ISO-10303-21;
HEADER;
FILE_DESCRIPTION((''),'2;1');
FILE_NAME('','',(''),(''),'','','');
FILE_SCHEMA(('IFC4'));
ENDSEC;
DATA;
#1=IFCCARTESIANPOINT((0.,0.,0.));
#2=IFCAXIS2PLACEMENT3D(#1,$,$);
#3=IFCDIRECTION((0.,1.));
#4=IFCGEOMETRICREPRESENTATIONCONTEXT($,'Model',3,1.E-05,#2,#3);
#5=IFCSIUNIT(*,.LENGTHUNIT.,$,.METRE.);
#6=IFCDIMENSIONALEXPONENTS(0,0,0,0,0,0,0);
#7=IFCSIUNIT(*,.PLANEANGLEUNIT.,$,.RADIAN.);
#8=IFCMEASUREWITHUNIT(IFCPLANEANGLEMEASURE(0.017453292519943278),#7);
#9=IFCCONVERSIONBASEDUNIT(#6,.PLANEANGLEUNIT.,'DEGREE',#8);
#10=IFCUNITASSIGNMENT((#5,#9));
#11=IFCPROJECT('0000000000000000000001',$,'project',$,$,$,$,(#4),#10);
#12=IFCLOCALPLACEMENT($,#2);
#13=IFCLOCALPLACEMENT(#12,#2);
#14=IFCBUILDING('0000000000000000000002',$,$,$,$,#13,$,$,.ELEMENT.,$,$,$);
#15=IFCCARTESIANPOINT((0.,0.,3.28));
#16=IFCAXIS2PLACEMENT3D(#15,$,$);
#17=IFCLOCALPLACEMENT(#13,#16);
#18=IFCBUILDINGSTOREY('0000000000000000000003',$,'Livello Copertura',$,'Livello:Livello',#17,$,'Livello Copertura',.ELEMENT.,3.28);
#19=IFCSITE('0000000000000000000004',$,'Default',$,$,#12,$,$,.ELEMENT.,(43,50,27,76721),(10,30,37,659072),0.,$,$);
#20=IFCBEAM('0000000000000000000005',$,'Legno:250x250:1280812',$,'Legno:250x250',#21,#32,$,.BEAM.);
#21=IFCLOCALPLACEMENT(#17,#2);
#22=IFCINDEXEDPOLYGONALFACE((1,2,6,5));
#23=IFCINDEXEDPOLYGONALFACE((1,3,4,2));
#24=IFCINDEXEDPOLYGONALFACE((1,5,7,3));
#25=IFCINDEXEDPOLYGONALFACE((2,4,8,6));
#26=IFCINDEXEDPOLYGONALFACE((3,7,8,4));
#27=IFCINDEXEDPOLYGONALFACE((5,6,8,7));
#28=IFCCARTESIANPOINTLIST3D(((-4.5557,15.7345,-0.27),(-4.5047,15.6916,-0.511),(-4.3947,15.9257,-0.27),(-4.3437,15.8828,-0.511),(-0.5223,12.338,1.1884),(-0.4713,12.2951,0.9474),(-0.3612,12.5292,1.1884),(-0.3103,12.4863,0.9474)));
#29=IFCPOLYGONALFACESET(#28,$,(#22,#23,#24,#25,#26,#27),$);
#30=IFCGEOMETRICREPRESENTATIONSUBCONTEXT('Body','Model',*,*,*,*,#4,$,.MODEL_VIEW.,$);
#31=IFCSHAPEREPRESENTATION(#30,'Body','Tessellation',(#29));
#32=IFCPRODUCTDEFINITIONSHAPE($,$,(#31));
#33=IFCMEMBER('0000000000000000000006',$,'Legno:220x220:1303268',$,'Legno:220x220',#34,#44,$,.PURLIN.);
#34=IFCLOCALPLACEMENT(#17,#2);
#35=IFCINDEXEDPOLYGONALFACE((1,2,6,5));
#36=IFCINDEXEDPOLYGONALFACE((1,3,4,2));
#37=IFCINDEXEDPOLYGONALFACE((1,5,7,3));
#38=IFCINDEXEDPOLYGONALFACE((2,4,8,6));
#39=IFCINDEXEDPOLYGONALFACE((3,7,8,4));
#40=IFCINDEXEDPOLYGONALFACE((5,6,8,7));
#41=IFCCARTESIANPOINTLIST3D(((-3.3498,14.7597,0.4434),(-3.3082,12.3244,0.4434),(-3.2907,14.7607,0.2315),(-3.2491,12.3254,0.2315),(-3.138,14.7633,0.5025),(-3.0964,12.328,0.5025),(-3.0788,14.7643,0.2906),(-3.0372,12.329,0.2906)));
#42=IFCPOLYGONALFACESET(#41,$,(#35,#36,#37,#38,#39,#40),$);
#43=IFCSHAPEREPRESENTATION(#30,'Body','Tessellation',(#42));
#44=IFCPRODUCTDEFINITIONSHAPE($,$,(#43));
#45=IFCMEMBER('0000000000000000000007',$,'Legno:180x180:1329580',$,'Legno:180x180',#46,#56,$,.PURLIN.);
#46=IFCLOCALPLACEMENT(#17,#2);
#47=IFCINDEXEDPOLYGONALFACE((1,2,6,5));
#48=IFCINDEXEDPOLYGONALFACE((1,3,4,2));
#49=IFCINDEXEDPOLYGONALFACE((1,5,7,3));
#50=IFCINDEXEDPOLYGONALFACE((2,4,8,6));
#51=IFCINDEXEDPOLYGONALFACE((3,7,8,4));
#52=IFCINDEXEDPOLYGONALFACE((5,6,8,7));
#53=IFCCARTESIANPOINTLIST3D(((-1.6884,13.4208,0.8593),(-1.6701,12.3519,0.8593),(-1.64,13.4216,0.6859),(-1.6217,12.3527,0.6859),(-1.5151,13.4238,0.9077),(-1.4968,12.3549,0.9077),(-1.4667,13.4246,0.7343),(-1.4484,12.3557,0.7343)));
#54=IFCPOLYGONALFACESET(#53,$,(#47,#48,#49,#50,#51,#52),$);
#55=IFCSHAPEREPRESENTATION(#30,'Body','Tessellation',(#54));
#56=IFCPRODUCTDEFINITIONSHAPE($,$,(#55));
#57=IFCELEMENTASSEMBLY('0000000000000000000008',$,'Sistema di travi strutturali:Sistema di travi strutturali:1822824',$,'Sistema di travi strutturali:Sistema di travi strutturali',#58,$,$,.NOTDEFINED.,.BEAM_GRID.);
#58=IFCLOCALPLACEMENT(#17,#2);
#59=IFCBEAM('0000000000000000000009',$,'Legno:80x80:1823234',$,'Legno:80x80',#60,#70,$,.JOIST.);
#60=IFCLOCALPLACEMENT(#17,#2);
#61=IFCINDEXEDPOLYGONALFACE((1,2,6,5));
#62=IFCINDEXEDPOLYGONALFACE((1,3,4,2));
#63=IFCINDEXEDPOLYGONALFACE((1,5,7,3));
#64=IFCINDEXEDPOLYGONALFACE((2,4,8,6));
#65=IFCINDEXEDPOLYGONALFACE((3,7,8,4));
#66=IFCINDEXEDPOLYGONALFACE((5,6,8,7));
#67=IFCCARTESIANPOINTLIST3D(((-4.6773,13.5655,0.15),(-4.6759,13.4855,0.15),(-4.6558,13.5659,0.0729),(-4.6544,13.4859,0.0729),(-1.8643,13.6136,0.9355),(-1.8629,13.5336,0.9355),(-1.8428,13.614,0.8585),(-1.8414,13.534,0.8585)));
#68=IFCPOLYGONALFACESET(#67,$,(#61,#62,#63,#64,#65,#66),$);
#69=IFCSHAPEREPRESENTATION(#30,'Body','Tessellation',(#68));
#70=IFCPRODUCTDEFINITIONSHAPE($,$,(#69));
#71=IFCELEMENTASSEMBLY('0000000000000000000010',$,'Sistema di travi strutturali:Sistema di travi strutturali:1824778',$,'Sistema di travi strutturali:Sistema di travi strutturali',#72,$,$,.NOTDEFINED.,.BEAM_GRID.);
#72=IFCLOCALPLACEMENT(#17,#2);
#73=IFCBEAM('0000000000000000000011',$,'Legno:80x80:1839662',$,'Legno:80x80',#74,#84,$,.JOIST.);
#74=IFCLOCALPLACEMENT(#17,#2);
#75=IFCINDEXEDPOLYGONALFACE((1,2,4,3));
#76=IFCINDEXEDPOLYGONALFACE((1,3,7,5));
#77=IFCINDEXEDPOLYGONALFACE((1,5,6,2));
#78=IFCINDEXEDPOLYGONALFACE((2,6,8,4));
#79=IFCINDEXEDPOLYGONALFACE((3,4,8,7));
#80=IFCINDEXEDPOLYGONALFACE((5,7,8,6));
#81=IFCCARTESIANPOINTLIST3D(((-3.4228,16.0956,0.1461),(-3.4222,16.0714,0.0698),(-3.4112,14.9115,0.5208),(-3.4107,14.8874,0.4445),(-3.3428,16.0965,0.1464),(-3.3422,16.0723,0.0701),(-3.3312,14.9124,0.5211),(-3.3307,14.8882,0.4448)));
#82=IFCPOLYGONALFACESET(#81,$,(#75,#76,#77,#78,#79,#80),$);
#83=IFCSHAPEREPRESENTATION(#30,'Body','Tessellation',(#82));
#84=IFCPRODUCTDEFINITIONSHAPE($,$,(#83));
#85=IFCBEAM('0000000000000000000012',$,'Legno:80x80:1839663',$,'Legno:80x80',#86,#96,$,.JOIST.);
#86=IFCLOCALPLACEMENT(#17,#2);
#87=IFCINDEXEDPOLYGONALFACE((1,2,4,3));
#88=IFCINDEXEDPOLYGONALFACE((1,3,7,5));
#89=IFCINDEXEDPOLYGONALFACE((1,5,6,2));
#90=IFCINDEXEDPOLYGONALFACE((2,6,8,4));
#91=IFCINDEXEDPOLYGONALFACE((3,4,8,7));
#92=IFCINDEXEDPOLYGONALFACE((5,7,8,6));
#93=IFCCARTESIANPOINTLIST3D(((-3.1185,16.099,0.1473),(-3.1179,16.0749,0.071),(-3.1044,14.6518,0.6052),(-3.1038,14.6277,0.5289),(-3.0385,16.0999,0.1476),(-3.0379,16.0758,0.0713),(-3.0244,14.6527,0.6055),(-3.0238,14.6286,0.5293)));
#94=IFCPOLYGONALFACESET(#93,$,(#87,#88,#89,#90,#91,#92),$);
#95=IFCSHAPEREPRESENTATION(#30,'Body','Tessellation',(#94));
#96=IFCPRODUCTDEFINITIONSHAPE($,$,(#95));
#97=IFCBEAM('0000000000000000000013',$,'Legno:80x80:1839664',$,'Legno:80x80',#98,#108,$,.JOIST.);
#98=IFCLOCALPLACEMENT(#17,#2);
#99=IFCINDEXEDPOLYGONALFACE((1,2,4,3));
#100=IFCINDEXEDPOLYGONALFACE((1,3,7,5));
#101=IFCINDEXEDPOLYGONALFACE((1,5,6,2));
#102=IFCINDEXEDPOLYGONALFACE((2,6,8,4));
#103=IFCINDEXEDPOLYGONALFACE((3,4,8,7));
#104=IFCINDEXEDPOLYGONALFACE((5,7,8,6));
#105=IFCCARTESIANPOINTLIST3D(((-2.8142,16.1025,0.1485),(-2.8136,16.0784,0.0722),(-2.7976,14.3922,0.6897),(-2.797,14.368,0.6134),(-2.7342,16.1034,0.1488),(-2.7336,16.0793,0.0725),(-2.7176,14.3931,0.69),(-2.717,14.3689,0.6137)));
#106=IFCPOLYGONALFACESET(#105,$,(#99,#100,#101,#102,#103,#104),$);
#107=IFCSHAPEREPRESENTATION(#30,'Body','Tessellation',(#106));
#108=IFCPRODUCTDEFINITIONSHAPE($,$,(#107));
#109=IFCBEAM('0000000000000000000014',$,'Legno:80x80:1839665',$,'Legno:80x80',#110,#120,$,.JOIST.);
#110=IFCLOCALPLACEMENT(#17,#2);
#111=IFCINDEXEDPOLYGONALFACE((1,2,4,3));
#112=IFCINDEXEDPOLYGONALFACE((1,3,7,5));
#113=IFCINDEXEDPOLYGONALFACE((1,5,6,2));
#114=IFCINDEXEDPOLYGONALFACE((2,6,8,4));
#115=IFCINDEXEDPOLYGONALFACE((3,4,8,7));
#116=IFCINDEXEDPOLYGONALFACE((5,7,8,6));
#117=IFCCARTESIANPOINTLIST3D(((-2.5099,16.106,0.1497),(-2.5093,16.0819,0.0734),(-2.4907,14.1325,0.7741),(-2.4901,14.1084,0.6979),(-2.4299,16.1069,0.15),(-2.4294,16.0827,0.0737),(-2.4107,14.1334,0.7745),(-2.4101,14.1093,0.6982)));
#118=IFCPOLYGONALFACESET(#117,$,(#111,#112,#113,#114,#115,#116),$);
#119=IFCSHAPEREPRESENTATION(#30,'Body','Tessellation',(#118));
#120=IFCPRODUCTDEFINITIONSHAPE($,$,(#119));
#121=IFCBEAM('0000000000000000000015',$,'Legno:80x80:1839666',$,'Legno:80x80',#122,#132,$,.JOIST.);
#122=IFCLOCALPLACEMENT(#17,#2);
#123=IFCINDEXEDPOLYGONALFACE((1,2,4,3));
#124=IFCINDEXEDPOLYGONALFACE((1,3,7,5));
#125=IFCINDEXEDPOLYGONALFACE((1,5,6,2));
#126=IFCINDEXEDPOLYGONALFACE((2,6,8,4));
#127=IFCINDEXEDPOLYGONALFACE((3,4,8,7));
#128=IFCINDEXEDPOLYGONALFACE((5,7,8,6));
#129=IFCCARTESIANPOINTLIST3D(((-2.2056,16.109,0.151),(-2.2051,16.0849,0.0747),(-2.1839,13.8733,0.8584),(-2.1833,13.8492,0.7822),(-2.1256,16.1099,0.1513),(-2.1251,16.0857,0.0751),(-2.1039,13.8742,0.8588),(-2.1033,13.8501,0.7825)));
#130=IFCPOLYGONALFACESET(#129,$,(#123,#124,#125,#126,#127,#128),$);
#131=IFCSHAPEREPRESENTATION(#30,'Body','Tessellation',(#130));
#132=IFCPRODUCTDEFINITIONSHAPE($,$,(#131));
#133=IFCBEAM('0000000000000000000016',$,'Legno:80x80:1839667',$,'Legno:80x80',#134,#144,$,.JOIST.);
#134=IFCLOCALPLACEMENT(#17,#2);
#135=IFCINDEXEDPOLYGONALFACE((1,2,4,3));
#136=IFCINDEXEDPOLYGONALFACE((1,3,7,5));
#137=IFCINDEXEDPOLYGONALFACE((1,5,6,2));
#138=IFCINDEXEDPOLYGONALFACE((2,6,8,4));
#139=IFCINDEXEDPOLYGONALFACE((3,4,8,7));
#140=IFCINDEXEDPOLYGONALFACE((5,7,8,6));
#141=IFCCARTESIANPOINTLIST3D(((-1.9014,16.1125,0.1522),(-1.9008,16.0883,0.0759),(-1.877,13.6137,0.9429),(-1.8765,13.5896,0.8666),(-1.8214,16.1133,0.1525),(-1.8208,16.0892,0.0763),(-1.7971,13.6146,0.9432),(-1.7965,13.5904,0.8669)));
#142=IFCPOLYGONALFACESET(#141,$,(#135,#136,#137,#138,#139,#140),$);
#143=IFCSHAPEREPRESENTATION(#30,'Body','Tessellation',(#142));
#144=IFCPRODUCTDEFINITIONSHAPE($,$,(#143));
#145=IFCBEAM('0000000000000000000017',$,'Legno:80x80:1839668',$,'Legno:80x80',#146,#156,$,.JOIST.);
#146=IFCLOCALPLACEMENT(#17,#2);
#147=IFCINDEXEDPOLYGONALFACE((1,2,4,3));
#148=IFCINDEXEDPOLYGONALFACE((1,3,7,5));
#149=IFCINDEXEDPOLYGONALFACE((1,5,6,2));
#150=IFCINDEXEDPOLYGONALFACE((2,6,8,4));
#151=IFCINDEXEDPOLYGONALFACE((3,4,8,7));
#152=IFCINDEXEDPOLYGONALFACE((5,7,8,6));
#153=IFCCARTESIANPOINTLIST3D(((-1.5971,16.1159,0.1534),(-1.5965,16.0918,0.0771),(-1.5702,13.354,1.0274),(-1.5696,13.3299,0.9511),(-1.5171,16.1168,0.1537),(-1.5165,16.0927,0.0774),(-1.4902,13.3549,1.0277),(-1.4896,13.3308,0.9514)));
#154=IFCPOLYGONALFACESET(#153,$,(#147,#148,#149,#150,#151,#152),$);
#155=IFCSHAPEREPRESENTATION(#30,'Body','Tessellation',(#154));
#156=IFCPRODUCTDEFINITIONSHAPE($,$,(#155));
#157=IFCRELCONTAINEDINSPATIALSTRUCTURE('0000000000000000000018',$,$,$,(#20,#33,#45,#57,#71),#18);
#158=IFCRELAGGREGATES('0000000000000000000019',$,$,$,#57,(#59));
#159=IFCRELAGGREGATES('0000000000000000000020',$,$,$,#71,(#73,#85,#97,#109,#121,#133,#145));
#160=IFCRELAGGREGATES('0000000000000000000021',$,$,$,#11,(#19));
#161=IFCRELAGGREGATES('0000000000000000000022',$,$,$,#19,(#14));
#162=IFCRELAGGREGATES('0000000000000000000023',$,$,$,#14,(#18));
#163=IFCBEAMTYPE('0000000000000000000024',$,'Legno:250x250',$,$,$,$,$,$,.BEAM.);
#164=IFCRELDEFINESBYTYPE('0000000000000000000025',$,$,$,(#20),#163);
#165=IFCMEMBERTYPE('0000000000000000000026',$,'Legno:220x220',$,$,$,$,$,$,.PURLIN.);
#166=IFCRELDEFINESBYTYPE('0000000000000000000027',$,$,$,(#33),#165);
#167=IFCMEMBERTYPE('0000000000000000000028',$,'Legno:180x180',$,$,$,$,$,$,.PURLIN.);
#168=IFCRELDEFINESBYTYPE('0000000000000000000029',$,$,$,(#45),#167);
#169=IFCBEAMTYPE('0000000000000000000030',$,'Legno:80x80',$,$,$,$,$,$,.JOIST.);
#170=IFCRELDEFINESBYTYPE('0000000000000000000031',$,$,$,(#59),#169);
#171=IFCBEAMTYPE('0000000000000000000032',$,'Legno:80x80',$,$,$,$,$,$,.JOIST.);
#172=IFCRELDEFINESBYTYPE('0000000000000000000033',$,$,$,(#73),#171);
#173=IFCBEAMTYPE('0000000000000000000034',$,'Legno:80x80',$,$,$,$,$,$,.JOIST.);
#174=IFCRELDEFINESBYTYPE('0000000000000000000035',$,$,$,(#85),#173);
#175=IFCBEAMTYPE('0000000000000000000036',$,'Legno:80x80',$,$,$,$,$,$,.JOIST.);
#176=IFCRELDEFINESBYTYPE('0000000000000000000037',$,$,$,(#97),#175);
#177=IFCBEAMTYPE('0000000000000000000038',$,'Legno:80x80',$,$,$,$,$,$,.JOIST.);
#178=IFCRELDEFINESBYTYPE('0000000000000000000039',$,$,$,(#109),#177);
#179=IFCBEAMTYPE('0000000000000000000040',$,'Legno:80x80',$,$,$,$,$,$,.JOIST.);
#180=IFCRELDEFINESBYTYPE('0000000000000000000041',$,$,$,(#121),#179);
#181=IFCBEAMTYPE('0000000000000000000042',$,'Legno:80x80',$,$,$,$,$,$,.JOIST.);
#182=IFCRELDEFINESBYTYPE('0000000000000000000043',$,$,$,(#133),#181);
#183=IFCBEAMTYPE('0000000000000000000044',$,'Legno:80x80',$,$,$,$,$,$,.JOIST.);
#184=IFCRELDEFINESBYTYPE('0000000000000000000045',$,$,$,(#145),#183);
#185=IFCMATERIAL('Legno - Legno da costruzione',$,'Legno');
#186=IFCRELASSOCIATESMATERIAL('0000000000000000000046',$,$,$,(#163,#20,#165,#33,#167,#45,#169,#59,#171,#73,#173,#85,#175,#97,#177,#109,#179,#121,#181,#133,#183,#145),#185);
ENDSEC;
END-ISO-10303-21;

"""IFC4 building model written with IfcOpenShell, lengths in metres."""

from ifc_helpers import new_model, entity, si_unit, converted_unit, direction, frame, origin, place, context, subcontext, project, spatial, indexed_curve, outline, extrude, source, transform, mapped, material, type_object, type_shapes, element, aggregate, save


model = new_model("IFC4")

# Units and contexts
model_context = context("Model", 3, precision=1e-05, world=origin(), true_north=direction((0.0, 1.0)))
body_context = subcontext(model_context, "Body", "Model", "MODEL_VIEW")
ifc_project = project(units=[si_unit("LENGTHUNIT", "METRE"), converted_unit("PLANEANGLEUNIT", "DEGREE", entity("IfcPlaneAngleMeasure", 0.017453292519943278), si_unit("PLANEANGLEUNIT", "RADIAN"), dimensions=[0, 0, 0, 0, 0, 0, 0])], contexts=[model_context])

# Site, building, storey
site_placement = place(None, origin())
site = spatial("IfcSite", under=ifc_project, at=site_placement, Name="Default", CompositionType="ELEMENT", RefLatitude=(43, 50, 27, 76721), RefLongitude=(10, 30, 37, 659072), RefElevation=0.0)
building_placement = place(site_placement, origin())
building = spatial("IfcBuilding", under=site, at=building_placement, CompositionType="ELEMENT")
storey_placement = place(building_placement, frame((0.0, 0.0, 3.28)))
storey = spatial("IfcBuildingStorey", under=building, at=storey_placement, Name="Livello Copertura", ObjectType="Livello:Livello", LongName="Livello Copertura", CompositionType="ELEMENT", Elevation=3.28)

# Beam
ifc_material = material(Name="Legno - Legno da costruzione", Category="Legno")
beam_type_1 = type_object("IfcBeamType", Name="Legno:250x250", PredefinedType="BEAM", material=ifc_material)
shared_shape_1 = source(origin(), body_context, "Body", "SweptSolid", [
    extrude(outline(indexed_curve([(-0.125, -2.7355), (0.125, -2.7355), (0.125, 2.7355), (-0.125, 2.7355), (-0.125, -2.7355)], self_intersect=False)), frame((-0.095, 0.0, -0.125), z_axis=(0.0, 0.0, 1.0), x_axis=(0.0, 1.0, 0.0)), (0.0, 0.0, 1.0), 0.25),
])
type_shapes(beam_type_1, [shared_shape_1])
beam_1_placement = place(storey_placement, frame((-2.3629, 14.0514, 0.364), z_axis=(-0.203897, 0.171699, 0.963818), x_axis=(0.737242, -0.620821, 0.266561)))
element("IfcBeam", 1, at=beam_1_placement, inside=storey, type_object=beam_type_1, material=ifc_material, Name="Legno:250x250:1280812", ObjectType="Legno:250x250", PredefinedType="BEAM", context=body_context, shape_type="MappedRepresentation", body=[
    mapped(shared_shape_1, transform((0.0, 0.0, 0.0), scale=1.0)),
])

# Members
member_type_1 = type_object("IfcMemberType", Name="Legno:220x220", PredefinedType="PURLIN", material=ifc_material)
shared_shape_2 = source(origin(), body_context, "Body", "SweptSolid", [
    extrude(outline(indexed_curve([(-1.2178, -0.11), (1.2178, -0.11), (1.2178, 0.11), (-1.2178, 0.11), (-1.2178, -0.11)], self_intersect=False)), frame((0.7007, 0.0, -0.11), z_axis=(0.0, 0.0, 1.0), x_axis=(-1.0, 0.0, 0.0)), (0.0, 0.0, 1.0), 0.22),
])
type_shapes(member_type_1, [shared_shape_2])
member_1_placement = place(storey_placement, frame((-3.2055, 14.2449, 0.367), z_axis=(-0.268881, -0.004594, 0.963163), x_axis=(0.017085, -0.999854, 0.0)))
element("IfcMember", 2, at=member_1_placement, inside=storey, type_object=member_type_1, material=ifc_material, Name="Legno:220x220:1303268", ObjectType="Legno:220x220", PredefinedType="PURLIN", context=body_context, shape_type="MappedRepresentation", body=[
    mapped(shared_shape_2, transform((0.0, 0.0, 0.0), scale=1.0)),
])
member_type_2 = type_object("IfcMemberType", Name="Legno:180x180", PredefinedType="PURLIN", material=ifc_material)
shared_shape_3 = source(origin(), body_context, "Body", "SweptSolid", [
    extrude(outline(indexed_curve([(-0.5345, -0.09), (0.5345, -0.09), (0.5345, 0.09), (-0.5345, 0.09), (-0.5345, -0.09)], self_intersect=False)), frame((1.3845, 0.0, -0.09), z_axis=(0.0, 0.0, 1.0), x_axis=(-1.0, 0.0, 0.0)), (0.0, 0.0, 1.0), 0.18),
])
type_shapes(member_type_2, [shared_shape_3])
member_2_placement = place(storey_placement, frame((-1.5921, 14.2725, 0.7968), z_axis=(-0.268881, -0.004594, 0.963163), x_axis=(0.017085, -0.999854, 0.0)))
element("IfcMember", 3, at=member_2_placement, inside=storey, type_object=member_type_2, material=ifc_material, Name="Legno:180x180:1329580", ObjectType="Legno:180x180", PredefinedType="PURLIN", context=body_context, shape_type="MappedRepresentation", body=[
    mapped(shared_shape_3, transform((0.0, 0.0, 0.0), scale=1.0)),
])

# Element assembly, beam
assembly_1_placement = place(storey_placement, origin())
assembly_1 = element("IfcElementAssembly", 4, at=assembly_1_placement, inside=storey, Name="Sistema di travi strutturali:Sistema di travi strutturali:1822824", ObjectType="Sistema di travi strutturali:Sistema di travi strutturali", AssemblyPlace="NOTDEFINED", PredefinedType="BEAM_GRID")
beam_type_2 = type_object("IfcBeamType", Name="Legno:80x80", PredefinedType="JOIST", material=ifc_material)
shared_shape_4 = source(origin(), body_context, "Body", "SweptSolid", [
    extrude(outline(indexed_curve([(-1.4605, -0.04), (1.4605, -0.04), (1.4605, 0.04), (-1.4605, 0.04), (-1.4605, -0.04)], self_intersect=False)), frame((0.0, 0.0, -0.04), z_axis=(0.0, 0.0, 1.0), x_axis=(-1.0, 0.0, 0.0)), (0.0, 0.0, 1.0), 0.08),
])
type_shapes(beam_type_2, [shared_shape_4])
beam_2_placement = place(assembly_1_placement, frame((-3.2593, 13.5498, 0.5042), z_axis=(-0.268881, -0.004594, 0.963163), x_axis=(0.963022, 0.016456, 0.26892)))
beam_2 = element("IfcBeam", 5, at=beam_2_placement, type_object=beam_type_2, material=ifc_material, Name="Legno:80x80:1823234", ObjectType="Legno:80x80", PredefinedType="JOIST", context=body_context, shape_type="MappedRepresentation", body=[
    mapped(shared_shape_4, transform((0.0, 0.0, 0.0), scale=1.0)),
])
aggregate(assembly_1, [beam_2])

# Element assembly, beams
assembly_2_placement = place(storey_placement, origin())
assembly_2 = element("IfcElementAssembly", 6, at=assembly_2_placement, inside=storey, Name="Sistema di travi strutturali:Sistema di travi strutturali:1824778", ObjectType="Sistema di travi strutturali:Sistema di travi strutturali", AssemblyPlace="NOTDEFINED", PredefinedType="BEAM_GRID")
beam_type_3 = type_object("IfcBeamType", Name="Legno:80x80", PredefinedType="JOIST", material=ifc_material)
shared_shape_5 = source(origin(), body_context, "Body", "SweptSolid", [
    extrude(outline(indexed_curve([(-0.621, -0.04), (0.621, -0.04), (0.621, 0.04), (-0.621, 0.04), (-0.621, -0.04)], self_intersect=False)), frame((0.0, 0.0, -0.04), z_axis=(0.0, 0.0, 1.0), x_axis=(-1.0, 0.0, 0.0)), (0.0, 0.0, 1.0), 0.08),
])
type_shapes(beam_type_3, [shared_shape_5])
beam_3_placement = place(assembly_2_placement, frame((-3.3767, 15.4919, 0.2954), z_axis=(-0.007187, 0.301619, 0.953402), x_axis=(0.009277, -0.953365, 0.301677)))
beam_3 = element("IfcBeam", 7, at=beam_3_placement, type_object=beam_type_3, material=ifc_material, Name="Legno:80x80:1839662", ObjectType="Legno:80x80", PredefinedType="JOIST", context=body_context, shape_type="MappedRepresentation", body=[
    mapped(shared_shape_5, transform((0.0, 0.0, 0.0), scale=1.0)),
])
beam_type_4 = type_object("IfcBeamType", Name="Legno:80x80", PredefinedType="JOIST", material=ifc_material)
shared_shape_6 = source(origin(), body_context, "Body", "SweptSolid", [
    extrude(outline(indexed_curve([(-0.759, -0.04), (0.759, -0.04), (0.759, 0.04), (-0.759, 0.04), (-0.759, -0.04)], self_intersect=False)), frame((0.0, 0.0, -0.04), z_axis=(0.0, 0.0, 1.0), x_axis=(-1.0, 0.0, 0.0)), (0.0, 0.0, 1.0), 0.08),
])
type_shapes(beam_type_4, [shared_shape_6])
beam_4_placement = place(assembly_2_placement, frame((-3.0712, 15.3638, 0.3383), z_axis=(-0.007187, 0.301619, 0.953402), x_axis=(0.009277, -0.953365, 0.301677)))
beam_4 = element("IfcBeam", 8, at=beam_4_placement, type_object=beam_type_4, material=ifc_material, Name="Legno:80x80:1839663", ObjectType="Legno:80x80", PredefinedType="JOIST", context=body_context, shape_type="MappedRepresentation", body=[
    mapped(shared_shape_6, transform((0.0, 0.0, 0.0), scale=1.0)),
])
beam_type_5 = type_object("IfcBeamType", Name="Legno:80x80", PredefinedType="JOIST", material=ifc_material)
shared_shape_7 = source(origin(), body_context, "Body", "SweptSolid", [
    extrude(outline(indexed_curve([(-0.897, -0.04), (0.897, -0.04), (0.897, 0.04), (-0.897, 0.04), (-0.897, -0.04)], self_intersect=False)), frame((0.0, 0.0, -0.04), z_axis=(0.0, 0.0, 1.0), x_axis=(-1.0, 0.0, 0.0)), (0.0, 0.0, 1.0), 0.08),
])
type_shapes(beam_type_5, [shared_shape_7])
beam_5_placement = place(assembly_2_placement, frame((-2.7656, 15.2357, 0.3811), z_axis=(-0.007187, 0.301619, 0.953402), x_axis=(0.009277, -0.953365, 0.301677)))
beam_5 = element("IfcBeam", 9, at=beam_5_placement, type_object=beam_type_5, material=ifc_material, Name="Legno:80x80:1839664", ObjectType="Legno:80x80", PredefinedType="JOIST", context=body_context, shape_type="MappedRepresentation", body=[
    mapped(shared_shape_7, transform((0.0, 0.0, 0.0), scale=1.0)),
])
beam_type_6 = type_object("IfcBeamType", Name="Legno:80x80", PredefinedType="JOIST", material=ifc_material)
shared_shape_8 = source(origin(), body_context, "Body", "SweptSolid", [
    extrude(outline(indexed_curve([(-1.035, -0.04), (1.035, -0.04), (1.035, 0.04), (-1.035, 0.04), (-1.035, -0.04)], self_intersect=False)), frame((0.0, 0.0, -0.04), z_axis=(0.0, 0.0, 1.0), x_axis=(-1.0, 0.0, 0.0)), (0.0, 0.0, 1.0), 0.08),
])
type_shapes(beam_type_6, [shared_shape_8])
beam_6_placement = place(assembly_2_placement, frame((-2.46, 15.1076, 0.4239), z_axis=(-0.007187, 0.301619, 0.953402), x_axis=(0.009277, -0.953365, 0.301677)))
beam_6 = element("IfcBeam", 10, at=beam_6_placement, type_object=beam_type_6, material=ifc_material, Name="Legno:80x80:1839665", ObjectType="Legno:80x80", PredefinedType="JOIST", context=body_context, shape_type="MappedRepresentation", body=[
    mapped(shared_shape_8, transform((0.0, 0.0, 0.0), scale=1.0)),
])
beam_type_7 = type_object("IfcBeamType", Name="Legno:80x80", PredefinedType="JOIST", material=ifc_material)
shared_shape_9 = source(origin(), body_context, "Body", "SweptSolid", [
    extrude(outline(indexed_curve([(-1.1725, -0.04), (1.1725, -0.04), (1.1725, 0.04), (-1.1725, 0.04), (-1.1725, -0.04)], self_intersect=False)), frame((0.0, 0.0, -0.04), z_axis=(0.0, 0.0, 1.0), x_axis=(-1.0, 0.0, 0.0)), (0.0, 0.0, 1.0), 0.08),
])
type_shapes(beam_type_7, [shared_shape_9])
beam_7_placement = place(assembly_2_placement, frame((-2.1545, 14.9795, 0.4667), z_axis=(-0.007187, 0.301619, 0.953402), x_axis=(0.009277, -0.953365, 0.301677)))
beam_7 = element("IfcBeam", 11, at=beam_7_placement, type_object=beam_type_7, material=ifc_material, Name="Legno:80x80:1839666", ObjectType="Legno:80x80", PredefinedType="JOIST", context=body_context, shape_type="MappedRepresentation", body=[
    mapped(shared_shape_9, transform((0.0, 0.0, 0.0), scale=1.0)),
])
beam_type_8 = type_object("IfcBeamType", Name="Legno:80x80", PredefinedType="JOIST", material=ifc_material)
shared_shape_10 = source(origin(), body_context, "Body", "SweptSolid", [
    extrude(outline(indexed_curve([(-1.3105, -0.04), (1.3105, -0.04), (1.3105, 0.04), (-1.3105, 0.04), (-1.3105, -0.04)], self_intersect=False)), frame((0.0, 0.0, -0.04), z_axis=(0.0, 0.0, 1.0), x_axis=(-1.0, 0.0, 0.0)), (0.0, 0.0, 1.0), 0.08),
])
type_shapes(beam_type_8, [shared_shape_10])
beam_8_placement = place(assembly_2_placement, frame((-1.8489, 14.8514, 0.5096), z_axis=(-0.007187, 0.301619, 0.953402), x_axis=(0.009277, -0.953365, 0.301677)))
beam_8 = element("IfcBeam", 12, at=beam_8_placement, type_object=beam_type_8, material=ifc_material, Name="Legno:80x80:1839667", ObjectType="Legno:80x80", PredefinedType="JOIST", context=body_context, shape_type="MappedRepresentation", body=[
    mapped(shared_shape_10, transform((0.0, 0.0, 0.0), scale=1.0)),
])
beam_type_9 = type_object("IfcBeamType", Name="Legno:80x80", PredefinedType="JOIST", material=ifc_material)
shared_shape_11 = source(origin(), body_context, "Body", "SweptSolid", [
    extrude(outline(indexed_curve([(-1.4485, -0.04), (1.4485, -0.04), (1.4485, 0.04), (-1.4485, 0.04), (-1.4485, -0.04)], self_intersect=False)), frame((0.0, 0.0, -0.04), z_axis=(0.0, 0.0, 1.0), x_axis=(-1.0, 0.0, 0.0)), (0.0, 0.0, 1.0), 0.08),
])
type_shapes(beam_type_9, [shared_shape_11])
beam_9_placement = place(assembly_2_placement, frame((-1.5434, 14.7234, 0.5524), z_axis=(-0.007187, 0.301619, 0.953402), x_axis=(0.009277, -0.953365, 0.301677)))
beam_9 = element("IfcBeam", 13, at=beam_9_placement, type_object=beam_type_9, material=ifc_material, Name="Legno:80x80:1839668", ObjectType="Legno:80x80", PredefinedType="JOIST", context=body_context, shape_type="MappedRepresentation", body=[
    mapped(shared_shape_11, transform((0.0, 0.0, 0.0), scale=1.0)),
])
aggregate(assembly_2, [beam_3, beam_4, beam_5, beam_6, beam_7, beam_8, beam_9])

save(model, "model.ifc")
